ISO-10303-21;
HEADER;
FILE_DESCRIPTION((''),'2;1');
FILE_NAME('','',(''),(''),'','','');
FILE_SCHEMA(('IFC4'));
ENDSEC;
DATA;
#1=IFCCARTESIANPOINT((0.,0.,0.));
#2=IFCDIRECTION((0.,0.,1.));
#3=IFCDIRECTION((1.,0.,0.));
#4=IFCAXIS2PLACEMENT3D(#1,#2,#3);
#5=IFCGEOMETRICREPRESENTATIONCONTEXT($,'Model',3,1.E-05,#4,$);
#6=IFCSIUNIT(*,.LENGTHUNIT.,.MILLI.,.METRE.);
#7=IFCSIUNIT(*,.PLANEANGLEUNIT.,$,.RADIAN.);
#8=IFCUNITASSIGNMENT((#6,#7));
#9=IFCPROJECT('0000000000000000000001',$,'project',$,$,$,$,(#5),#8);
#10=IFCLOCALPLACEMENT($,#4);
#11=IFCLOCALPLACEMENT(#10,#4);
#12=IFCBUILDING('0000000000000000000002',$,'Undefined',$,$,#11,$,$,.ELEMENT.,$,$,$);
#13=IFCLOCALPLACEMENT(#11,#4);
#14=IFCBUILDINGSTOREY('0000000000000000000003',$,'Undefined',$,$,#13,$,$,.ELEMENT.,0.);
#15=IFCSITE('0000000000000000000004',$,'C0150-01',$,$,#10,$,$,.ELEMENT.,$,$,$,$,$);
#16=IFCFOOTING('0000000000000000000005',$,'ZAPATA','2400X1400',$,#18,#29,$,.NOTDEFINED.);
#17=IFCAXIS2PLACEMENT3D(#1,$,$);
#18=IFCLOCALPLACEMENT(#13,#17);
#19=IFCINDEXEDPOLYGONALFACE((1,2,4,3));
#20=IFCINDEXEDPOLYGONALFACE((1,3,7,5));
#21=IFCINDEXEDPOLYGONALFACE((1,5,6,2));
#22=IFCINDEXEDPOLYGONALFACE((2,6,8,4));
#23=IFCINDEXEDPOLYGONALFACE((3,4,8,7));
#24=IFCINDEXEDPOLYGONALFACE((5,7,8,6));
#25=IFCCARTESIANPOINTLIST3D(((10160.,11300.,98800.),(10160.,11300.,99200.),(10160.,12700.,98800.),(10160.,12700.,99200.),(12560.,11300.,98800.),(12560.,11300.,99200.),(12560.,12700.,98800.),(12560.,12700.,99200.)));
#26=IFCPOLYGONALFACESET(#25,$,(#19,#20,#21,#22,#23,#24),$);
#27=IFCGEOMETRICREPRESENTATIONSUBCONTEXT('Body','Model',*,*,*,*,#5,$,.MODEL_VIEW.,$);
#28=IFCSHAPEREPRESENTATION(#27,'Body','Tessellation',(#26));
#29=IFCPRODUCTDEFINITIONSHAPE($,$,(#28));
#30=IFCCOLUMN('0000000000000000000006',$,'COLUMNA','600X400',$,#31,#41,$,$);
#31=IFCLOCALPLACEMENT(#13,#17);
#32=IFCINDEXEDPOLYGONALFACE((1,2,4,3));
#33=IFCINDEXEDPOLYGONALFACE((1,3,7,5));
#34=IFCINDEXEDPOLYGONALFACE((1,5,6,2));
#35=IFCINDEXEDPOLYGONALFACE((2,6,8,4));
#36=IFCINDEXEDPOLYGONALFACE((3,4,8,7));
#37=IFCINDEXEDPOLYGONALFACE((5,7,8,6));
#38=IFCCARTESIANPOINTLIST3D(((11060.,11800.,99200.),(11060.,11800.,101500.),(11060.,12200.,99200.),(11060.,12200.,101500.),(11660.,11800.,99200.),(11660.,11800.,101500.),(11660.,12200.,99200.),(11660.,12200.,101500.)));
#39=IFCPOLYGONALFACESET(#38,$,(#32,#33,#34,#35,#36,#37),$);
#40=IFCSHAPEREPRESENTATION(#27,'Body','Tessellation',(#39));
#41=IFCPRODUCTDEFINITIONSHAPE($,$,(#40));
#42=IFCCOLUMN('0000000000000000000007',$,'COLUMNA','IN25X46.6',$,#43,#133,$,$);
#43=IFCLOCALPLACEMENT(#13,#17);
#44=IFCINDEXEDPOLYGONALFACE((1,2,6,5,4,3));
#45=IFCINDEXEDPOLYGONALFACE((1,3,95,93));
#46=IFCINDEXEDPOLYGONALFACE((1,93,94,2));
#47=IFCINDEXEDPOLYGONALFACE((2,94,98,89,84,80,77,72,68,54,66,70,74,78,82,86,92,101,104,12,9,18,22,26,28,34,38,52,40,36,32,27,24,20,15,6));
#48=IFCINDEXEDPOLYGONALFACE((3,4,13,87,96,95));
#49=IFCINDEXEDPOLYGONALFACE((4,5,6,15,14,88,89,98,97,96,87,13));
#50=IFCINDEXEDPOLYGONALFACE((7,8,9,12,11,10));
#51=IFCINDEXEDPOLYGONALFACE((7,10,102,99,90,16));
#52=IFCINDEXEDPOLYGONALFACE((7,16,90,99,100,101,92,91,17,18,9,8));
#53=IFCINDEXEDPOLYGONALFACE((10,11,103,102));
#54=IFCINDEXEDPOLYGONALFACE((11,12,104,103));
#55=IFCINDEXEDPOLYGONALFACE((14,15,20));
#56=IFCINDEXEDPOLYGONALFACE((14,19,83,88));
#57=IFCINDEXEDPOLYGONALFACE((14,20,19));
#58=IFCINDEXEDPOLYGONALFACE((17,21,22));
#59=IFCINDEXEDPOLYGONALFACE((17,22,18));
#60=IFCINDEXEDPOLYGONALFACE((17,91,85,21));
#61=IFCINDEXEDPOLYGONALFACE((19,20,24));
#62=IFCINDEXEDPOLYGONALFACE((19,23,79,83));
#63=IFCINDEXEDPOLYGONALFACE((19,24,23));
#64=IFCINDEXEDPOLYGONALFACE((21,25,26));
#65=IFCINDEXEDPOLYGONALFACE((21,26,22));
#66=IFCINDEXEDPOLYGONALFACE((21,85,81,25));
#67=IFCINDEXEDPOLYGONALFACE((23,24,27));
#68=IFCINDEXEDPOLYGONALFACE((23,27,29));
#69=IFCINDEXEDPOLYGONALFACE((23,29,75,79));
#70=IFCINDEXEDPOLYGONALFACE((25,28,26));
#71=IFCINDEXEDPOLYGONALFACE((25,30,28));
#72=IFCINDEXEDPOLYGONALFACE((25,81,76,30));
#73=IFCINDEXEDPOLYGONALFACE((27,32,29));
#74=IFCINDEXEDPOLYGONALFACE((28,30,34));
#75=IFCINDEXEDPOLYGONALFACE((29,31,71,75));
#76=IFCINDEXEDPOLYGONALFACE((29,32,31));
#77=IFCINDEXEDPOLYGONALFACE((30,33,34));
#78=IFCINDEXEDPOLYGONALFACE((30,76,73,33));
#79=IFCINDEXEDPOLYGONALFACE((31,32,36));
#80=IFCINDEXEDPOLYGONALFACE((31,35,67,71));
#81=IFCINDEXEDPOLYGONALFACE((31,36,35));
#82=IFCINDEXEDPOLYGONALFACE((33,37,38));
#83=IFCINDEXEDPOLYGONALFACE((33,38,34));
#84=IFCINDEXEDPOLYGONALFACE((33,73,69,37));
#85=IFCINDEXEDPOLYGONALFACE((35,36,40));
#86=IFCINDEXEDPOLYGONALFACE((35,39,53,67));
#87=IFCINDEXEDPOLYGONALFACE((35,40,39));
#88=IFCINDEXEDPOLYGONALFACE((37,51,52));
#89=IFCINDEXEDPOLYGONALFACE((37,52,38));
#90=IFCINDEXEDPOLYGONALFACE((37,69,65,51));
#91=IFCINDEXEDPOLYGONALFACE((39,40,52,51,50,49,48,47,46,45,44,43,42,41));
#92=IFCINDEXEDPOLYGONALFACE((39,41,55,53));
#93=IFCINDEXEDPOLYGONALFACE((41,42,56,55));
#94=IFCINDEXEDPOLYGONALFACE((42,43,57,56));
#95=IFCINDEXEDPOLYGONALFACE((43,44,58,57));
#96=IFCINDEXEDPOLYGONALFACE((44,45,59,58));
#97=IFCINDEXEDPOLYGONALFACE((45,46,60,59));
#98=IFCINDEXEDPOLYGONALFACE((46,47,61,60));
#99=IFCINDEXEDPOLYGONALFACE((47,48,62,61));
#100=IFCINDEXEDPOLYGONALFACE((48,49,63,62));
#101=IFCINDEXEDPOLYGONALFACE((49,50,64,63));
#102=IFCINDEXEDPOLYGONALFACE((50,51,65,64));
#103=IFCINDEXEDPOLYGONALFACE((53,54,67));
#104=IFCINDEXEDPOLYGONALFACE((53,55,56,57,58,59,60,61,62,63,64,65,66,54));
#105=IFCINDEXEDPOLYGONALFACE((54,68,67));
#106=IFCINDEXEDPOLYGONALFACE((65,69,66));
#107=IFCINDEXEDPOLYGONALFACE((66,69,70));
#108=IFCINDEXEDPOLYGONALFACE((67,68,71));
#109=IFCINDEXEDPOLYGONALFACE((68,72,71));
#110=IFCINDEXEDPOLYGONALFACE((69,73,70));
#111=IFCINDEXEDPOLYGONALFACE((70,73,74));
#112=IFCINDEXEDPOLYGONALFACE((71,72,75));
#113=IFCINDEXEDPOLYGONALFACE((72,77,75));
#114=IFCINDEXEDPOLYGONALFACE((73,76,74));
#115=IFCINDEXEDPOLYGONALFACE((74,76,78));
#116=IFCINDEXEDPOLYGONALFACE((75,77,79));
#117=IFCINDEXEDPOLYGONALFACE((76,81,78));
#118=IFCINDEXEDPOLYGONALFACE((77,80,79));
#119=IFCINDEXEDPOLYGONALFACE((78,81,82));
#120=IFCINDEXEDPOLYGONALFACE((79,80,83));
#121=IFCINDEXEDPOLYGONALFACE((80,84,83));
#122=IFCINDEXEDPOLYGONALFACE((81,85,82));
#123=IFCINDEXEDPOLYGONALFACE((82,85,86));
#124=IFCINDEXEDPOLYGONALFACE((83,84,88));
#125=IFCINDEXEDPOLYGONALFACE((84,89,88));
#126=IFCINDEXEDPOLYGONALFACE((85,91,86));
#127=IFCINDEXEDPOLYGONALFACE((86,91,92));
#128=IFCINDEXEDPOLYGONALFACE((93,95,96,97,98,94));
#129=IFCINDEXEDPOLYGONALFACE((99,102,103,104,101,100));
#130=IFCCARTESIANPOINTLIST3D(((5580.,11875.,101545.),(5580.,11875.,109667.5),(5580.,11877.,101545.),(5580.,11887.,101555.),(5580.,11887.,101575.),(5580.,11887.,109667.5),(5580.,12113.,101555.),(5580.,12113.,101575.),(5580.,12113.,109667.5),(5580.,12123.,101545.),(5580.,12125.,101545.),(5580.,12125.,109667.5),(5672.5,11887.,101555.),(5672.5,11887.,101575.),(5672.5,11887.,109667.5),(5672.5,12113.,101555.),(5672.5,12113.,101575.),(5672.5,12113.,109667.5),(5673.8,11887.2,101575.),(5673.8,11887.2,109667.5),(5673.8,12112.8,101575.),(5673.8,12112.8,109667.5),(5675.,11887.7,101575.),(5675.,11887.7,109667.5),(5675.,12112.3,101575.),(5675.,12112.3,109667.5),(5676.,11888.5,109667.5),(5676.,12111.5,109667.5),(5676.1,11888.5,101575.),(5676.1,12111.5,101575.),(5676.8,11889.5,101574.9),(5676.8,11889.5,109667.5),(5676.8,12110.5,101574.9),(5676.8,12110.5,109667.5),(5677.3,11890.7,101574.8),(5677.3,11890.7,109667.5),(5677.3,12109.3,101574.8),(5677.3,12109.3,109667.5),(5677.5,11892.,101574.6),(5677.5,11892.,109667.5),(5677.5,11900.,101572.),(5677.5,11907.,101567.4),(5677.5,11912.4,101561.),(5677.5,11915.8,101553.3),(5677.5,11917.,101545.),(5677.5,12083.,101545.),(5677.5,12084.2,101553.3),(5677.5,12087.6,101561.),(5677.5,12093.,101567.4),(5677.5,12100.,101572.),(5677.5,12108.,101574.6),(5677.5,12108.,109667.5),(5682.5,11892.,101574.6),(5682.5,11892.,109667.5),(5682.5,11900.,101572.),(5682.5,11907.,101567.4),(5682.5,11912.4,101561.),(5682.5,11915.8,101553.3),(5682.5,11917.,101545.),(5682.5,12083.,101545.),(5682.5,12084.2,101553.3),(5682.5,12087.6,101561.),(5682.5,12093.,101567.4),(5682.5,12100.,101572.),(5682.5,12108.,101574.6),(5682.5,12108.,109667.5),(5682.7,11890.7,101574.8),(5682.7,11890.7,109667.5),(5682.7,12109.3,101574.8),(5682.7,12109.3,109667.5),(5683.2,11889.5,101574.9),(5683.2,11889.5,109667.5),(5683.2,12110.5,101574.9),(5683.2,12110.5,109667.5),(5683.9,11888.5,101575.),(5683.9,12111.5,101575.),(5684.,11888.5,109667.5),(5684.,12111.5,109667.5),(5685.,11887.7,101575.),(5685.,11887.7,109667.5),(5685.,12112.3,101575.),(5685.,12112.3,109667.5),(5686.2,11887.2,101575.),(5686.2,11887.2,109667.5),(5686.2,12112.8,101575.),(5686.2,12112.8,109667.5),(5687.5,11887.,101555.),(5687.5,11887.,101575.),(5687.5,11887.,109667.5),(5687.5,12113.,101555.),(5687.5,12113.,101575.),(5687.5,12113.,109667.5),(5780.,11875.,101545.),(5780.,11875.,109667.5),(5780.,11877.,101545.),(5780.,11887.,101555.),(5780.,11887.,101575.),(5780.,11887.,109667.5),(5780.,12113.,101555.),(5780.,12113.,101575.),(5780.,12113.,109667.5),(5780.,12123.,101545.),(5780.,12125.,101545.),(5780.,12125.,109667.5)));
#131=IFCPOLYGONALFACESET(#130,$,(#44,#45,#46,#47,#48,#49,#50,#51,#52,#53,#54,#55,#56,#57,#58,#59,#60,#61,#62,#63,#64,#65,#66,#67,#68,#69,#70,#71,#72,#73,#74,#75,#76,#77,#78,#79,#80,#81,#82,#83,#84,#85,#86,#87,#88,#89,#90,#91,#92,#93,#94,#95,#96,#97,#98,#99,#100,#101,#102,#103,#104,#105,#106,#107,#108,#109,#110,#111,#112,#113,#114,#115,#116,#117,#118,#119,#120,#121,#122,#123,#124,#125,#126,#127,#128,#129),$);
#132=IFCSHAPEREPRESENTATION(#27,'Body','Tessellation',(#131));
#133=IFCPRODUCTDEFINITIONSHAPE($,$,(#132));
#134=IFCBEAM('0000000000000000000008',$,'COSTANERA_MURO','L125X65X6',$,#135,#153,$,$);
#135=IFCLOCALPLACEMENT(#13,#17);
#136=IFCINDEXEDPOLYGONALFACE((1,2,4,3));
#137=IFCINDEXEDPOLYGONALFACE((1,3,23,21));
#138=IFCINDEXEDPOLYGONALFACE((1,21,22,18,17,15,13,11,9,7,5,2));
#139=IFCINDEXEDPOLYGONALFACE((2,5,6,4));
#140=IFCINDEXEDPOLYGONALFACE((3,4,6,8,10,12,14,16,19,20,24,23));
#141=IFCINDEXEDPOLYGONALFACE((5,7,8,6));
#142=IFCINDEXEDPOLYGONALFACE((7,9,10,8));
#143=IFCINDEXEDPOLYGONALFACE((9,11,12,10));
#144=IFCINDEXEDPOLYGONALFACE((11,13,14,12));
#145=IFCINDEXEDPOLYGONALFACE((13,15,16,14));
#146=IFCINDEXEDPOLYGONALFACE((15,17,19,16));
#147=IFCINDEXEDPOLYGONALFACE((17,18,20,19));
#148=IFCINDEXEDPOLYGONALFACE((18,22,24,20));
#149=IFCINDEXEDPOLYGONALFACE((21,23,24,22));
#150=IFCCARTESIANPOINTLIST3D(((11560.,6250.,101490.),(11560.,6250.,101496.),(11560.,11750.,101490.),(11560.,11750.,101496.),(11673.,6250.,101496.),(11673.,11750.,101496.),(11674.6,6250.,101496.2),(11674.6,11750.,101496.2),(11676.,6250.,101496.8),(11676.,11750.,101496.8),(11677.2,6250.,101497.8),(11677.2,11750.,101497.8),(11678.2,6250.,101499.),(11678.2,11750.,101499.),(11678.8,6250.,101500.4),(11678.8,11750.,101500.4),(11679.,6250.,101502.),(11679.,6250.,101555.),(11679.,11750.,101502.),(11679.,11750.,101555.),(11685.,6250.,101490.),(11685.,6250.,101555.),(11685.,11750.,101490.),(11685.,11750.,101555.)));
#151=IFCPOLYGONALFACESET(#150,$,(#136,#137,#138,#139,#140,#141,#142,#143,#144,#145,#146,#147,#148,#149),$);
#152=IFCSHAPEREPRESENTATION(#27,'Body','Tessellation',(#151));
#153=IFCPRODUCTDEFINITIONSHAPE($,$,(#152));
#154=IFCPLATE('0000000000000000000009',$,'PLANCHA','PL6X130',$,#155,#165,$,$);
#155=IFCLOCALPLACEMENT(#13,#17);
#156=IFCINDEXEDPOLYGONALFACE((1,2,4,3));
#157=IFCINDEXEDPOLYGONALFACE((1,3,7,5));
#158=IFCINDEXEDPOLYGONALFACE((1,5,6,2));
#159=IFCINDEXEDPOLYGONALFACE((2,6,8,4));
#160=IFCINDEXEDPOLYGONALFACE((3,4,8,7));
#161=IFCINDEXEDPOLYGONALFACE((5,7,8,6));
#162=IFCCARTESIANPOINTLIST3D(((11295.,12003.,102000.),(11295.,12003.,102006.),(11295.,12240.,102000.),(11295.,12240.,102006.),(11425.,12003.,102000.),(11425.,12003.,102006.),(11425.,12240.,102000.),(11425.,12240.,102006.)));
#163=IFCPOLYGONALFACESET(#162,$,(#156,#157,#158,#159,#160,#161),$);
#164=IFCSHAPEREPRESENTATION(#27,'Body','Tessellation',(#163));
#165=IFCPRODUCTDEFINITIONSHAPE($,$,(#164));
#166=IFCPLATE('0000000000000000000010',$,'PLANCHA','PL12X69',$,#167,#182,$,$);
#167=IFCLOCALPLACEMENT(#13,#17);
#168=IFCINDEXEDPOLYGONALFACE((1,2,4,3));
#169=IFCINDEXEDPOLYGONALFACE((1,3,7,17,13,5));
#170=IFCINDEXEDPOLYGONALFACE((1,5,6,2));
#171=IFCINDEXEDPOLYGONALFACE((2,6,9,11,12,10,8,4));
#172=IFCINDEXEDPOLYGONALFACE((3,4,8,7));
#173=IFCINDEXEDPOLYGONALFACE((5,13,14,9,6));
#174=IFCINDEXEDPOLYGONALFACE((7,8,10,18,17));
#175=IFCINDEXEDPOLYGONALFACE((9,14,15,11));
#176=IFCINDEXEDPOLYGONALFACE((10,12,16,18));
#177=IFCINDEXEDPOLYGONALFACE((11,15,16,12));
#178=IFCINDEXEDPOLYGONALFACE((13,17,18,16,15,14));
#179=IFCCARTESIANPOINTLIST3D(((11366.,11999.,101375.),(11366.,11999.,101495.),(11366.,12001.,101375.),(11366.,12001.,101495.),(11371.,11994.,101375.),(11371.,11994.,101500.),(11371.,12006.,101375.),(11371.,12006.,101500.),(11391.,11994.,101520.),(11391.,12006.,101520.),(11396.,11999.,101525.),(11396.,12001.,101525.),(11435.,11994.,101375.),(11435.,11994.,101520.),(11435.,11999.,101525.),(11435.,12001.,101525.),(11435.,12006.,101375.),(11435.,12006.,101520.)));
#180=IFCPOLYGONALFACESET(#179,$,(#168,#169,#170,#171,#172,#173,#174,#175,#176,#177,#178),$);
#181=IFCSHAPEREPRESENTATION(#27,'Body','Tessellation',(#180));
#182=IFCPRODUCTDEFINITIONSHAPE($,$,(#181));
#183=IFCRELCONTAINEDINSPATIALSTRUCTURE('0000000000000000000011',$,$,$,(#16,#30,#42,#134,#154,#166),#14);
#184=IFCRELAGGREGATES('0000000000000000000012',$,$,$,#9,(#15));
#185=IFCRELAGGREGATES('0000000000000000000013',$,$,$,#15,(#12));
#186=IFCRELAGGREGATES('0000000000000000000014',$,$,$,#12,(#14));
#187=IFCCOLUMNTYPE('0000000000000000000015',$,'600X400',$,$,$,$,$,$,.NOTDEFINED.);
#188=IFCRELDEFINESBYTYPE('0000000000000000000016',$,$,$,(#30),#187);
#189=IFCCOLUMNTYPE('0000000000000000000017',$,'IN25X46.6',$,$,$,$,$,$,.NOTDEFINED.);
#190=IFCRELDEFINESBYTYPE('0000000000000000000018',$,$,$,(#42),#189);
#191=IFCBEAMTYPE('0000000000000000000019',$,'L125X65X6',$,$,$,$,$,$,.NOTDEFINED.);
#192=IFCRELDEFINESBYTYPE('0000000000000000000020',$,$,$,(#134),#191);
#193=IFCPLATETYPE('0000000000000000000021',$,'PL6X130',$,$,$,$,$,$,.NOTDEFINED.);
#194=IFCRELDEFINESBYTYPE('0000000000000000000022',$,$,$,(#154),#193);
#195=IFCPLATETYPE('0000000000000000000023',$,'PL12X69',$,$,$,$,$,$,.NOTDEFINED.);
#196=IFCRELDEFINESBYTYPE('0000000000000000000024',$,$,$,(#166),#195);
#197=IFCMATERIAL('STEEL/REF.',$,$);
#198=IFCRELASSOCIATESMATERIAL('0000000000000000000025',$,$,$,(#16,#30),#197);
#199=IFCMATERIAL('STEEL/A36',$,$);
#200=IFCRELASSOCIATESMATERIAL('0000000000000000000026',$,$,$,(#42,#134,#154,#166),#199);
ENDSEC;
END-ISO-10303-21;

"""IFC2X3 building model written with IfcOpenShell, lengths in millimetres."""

from ifc_helpers import new_model, si_unit, frame, origin_with_axes, origin_2d_with_axis, place, context, subcontext, project, spatial, polyline, circle_curve, parameter, trimmed, segment, composite_curve, rectangle, i_section, l_section, outline, extrude, boolean, halfspace, material, type_object, element, save


model = new_model("IFC2X3")

# Units and contexts
model_context = context("Model", 3, precision=1e-05, world=origin_with_axes())
body_context = subcontext(model_context, "Body", "Model", "MODEL_VIEW")
ifc_project = project(units=[si_unit("LENGTHUNIT", "METRE", prefix="MILLI"), si_unit("PLANEANGLEUNIT", "RADIAN")], contexts=[model_context])

# Site, building, storey
site_placement = place(None, origin_with_axes())
site = spatial("IfcSite", under=ifc_project, at=site_placement, Name="C0150-01", CompositionType="ELEMENT")
building_placement = place(site_placement, origin_with_axes())
building = spatial("IfcBuilding", under=site, at=building_placement, Name="Undefined", CompositionType="ELEMENT")
storey_placement = place(building_placement, origin_with_axes())
storey = spatial("IfcBuildingStorey", under=building, at=storey_placement, Name="Undefined", CompositionType="ELEMENT", Elevation=0.0)

# Footing
ifc_material_1 = material(Name="STEEL/REF.")
footing_placement = place(storey_placement, frame((11360.0, 12000.0, 98800.0), z_axis=(-1.0, 0.0, 0.0), x_axis=(0.0, 0.0, 1.0)))
element("IfcFooting", 1, at=footing_placement, inside=storey, material=ifc_material_1, Name="ZAPATA", Description="2400X1400", PredefinedType="NOTDEFINED", context=body_context, shape_type="SweptSolid", body=[
    extrude(rectangle(XDim=1400.0, YDim=2400.0, at=origin_2d_with_axis()), frame((400.0, 0.0, 0.0), z_axis=(-1.0, 0.0, 0.0), x_axis=(0.0, -1.0, 0.0)), (0.0, 0.0, 1.0), 400.0),
])

# Columns
column_type_1 = type_object("IfcColumnType", Name="600X400", PredefinedType="NOTDEFINED")
column_1_placement = place(storey_placement, frame((11360.0, 12000.0, 99200.0), z_axis=(0.0, 0.0, 1.0), x_axis=(-1.0, 0.0, 0.0)))
element("IfcColumn", 2, at=column_1_placement, inside=storey, type_object=column_type_1, material=ifc_material_1, Name="COLUMNA", Description="600X400", context=body_context, shape_type="SweptSolid", body=[
    extrude(rectangle(XDim=400.0, YDim=600.0, at=origin_2d_with_axis()), frame((0.0, 0.0, 2300.0), z_axis=(0.0, 0.0, -1.0), x_axis=(0.0, 1.0, 0.0)), (0.0, 0.0, 1.0), 2300.0),
])
ifc_material_2 = material(Name="STEEL/A36")
column_type_2 = type_object("IfcColumnType", Name="IN25X46.6", PredefinedType="NOTDEFINED")
column_2_placement = place(storey_placement, frame((5680.0, 12000.0, 101525.0), z_axis=(0.0, 0.0, 1.0), x_axis=(0.0, -1.0, 0.0)))
element("IfcColumn", 3, at=column_2_placement, inside=storey, type_object=column_type_2, material=ifc_material_2, Name="COLUMNA", Description="IN25X46.6", context=body_context, shape_type="CSG", body=[
    boolean("DIFFERENCE", boolean("DIFFERENCE", boolean("DIFFERENCE", boolean("DIFFERENCE", boolean("DIFFERENCE", boolean("DIFFERENCE", extrude(i_section(OverallWidth=200.0, OverallDepth=250.0, WebThickness=5.0, FlangeThickness=12.0, FilletRadius=5.0, at=origin_2d_with_axis()), frame((0.0, 0.0, 8401.2), z_axis=(0.0, 0.0, -1.0), x_axis=(0.0, 1.0, 0.0)), (0.0, 0.0, 1.0), 8401.2), extrude(outline(polyline([(0.0, 0.0), (14.1, 0.0), (7.1, 7.1), (0.0, 0.0)])), frame((-113.0, 103.0, 30.0), z_axis=(0.0, -1.0, 0.0), x_axis=(-0.707107, 0.0, -0.707107)), (0.0, 0.0, 1.0), 206.0)), extrude(outline(composite_curve([segment(polyline([(0.0, 0.0), (30.0, 0.0)]), True, "CONTINUOUS"), segment(trimmed(circle_curve(origin_2d_with_axis(), 30.0), [parameter(0.0)], [parameter(1.570796)], True, "PARAMETER"), True, "CONTINUOUS"), segment(polyline([(0.0, 30.0), (0.0, 0.0)]), True, "CONTINUOUS")], self_intersect=True)), frame((-113.0, -103.0, 20.0), z_axis=(0.0, 1.0, 0.0), x_axis=(0.0, 0.0, 1.0)), (0.0, 0.0, 1.0), 206.0)), extrude(outline(composite_curve([segment(polyline([(0.0, 0.0), (30.0, 0.0)]), True, "CONTINUOUS"), segment(trimmed(circle_curve(origin_2d_with_axis(), 30.0), [parameter(0.0)], [parameter(1.570796)], True, "PARAMETER"), True, "CONTINUOUS"), segment(polyline([(0.0, 30.0), (0.0, 0.0)]), True, "CONTINUOUS")], self_intersect=True)), frame((113.0, 103.0, 20.0), z_axis=(0.0, -1.0, 0.0), x_axis=(0.0, 0.0, 1.0)), (0.0, 0.0, 1.0), 206.0)), extrude(outline(polyline([(0.0, 0.0), (14.1, 0.0), (7.1, 7.1), (0.0, 0.0)])), frame((113.0, -103.0, 30.0), z_axis=(0.0, 1.0, 0.0), x_axis=(0.707107, 0.0, -0.707107)), (0.0, 0.0, 1.0), 206.0)), halfspace(frame((125.0, 0.0, 8142.5), z_axis=(0.0, 0.0, -1.0), x_axis=(0.0, 1.0, 0.0)), True)), halfspace(frame((0.0, 100.0, 20.0), z_axis=(0.0, 0.0, 1.0), x_axis=(1.0, 0.0, 0.0)), True)),
])

# Beam
beam_type = type_object("IfcBeamType", Name="L125X65X6", PredefinedType="NOTDEFINED")
beam_placement = place(storey_placement, frame((11622.5, 6250.0, 101522.5), z_axis=(-1.0, 0.0, 0.0), x_axis=(0.0, 1.0, 0.0)))
element("IfcBeam", 4, at=beam_placement, inside=storey, type_object=beam_type, material=ifc_material_2, Name="COSTANERA_MURO", Description="L125X65X6", context=body_context, shape_type="SweptSolid", body=[
    extrude(l_section(Depth=125.0, Width=65.0, Thickness=6.0, FilletRadius=6.0, at=origin_2d_with_axis()), frame((5500.0, 0.0, 0.0), z_axis=(-1.0, 0.0, 0.0), x_axis=(0.0, -1.0, 0.0)), (0.0, 0.0, 1.0), 5500.0),
])

# Plates
plate_type_1 = type_object("IfcPlateType", Name="PL6X130", PredefinedType="NOTDEFINED")
plate_1_placement = place(storey_placement, frame((11295.0, 12003.0, 102003.0), z_axis=(0.0, -0.000002, 1.0), x_axis=(1.0, 0.0, 0.0)))
element("IfcPlate", 5, at=plate_1_placement, inside=storey, type_object=plate_type_1, material=ifc_material_2, Name="PLANCHA", Description="PL6X130", context=body_context, shape_type="SweptSolid", body=[
    extrude(outline(polyline([(0.0, 0.0), (130.0, 0.0), (130.0, 237.0), (0.0, 237.0), (0.0, 0.0)])), frame((0.0, 0.0, -3.0), z_axis=(0.0, 0.0, 1.0), x_axis=(1.0, 0.0, 0.0)), (0.0, 0.0, 1.0), 6.0),
])
plate_type_2 = type_object("IfcPlateType", Name="PL12X69", PredefinedType="NOTDEFINED")
plate_2_placement = place(storey_placement, frame((11435.0, 12000.0, 101525.0), z_axis=(0.0, 1.0, 0.0), x_axis=(0.0, 0.0, -1.0)))
element("IfcPlate", 6, at=plate_2_placement, inside=storey, type_object=plate_type_2, material=ifc_material_2, Name="PLANCHA", Description="PL12X69", context=body_context, shape_type="CSG", body=[
    boolean("DIFFERENCE", boolean("DIFFERENCE", boolean("DIFFERENCE", boolean("DIFFERENCE", extrude(outline(polyline([(0.0, 0.0), (150.0, 0.0), (150.0, 69.0), (30.0, 69.0), (0.0, 39.0), (0.0, 0.0)])), frame((0.0, 0.0, -6.0), z_axis=(0.0, 0.0, 1.0), x_axis=(1.0, 0.0, 0.0)), (0.0, 0.0, 1.0), 12.0), extrude(outline(polyline([(0.0, 0.0), (5.0, 0.0), (5.0, 5.0), (0.0, 0.0)])), frame((-2.5, 69.0, 1.0), z_axis=(1.0, 0.0, 0.0), x_axis=(0.0, 0.0, 1.0)), (0.0, 0.0, 1.0), 155.0)), extrude(outline(polyline([(0.0, 0.0), (5.0, 0.0), (5.0, 5.0), (0.0, 0.0)])), frame((152.5, 69.0, -1.0), z_axis=(-1.0, 0.0, 0.0), x_axis=(0.0, 0.0, -1.0)), (0.0, 0.0, 1.0), 155.0)), extrude(outline(polyline([(0.0, 0.0), (5.0, 0.0), (5.0, 5.0), (0.0, 0.0)])), frame((0.0, -29.5, 1.0), z_axis=(0.0, 1.0, 0.0), x_axis=(0.0, 0.0, 1.0)), (0.0, 0.0, 1.0), 101.0)), extrude(outline(polyline([(0.0, 0.0), (5.0, 0.0), (5.0, 5.0), (0.0, 0.0)])), frame((0.0, 71.5, -1.0), z_axis=(0.0, -1.0, 0.0), x_axis=(0.0, 0.0, -1.0)), (0.0, 0.0, 1.0), 101.0)),
])

save(model, "model.ifc")
